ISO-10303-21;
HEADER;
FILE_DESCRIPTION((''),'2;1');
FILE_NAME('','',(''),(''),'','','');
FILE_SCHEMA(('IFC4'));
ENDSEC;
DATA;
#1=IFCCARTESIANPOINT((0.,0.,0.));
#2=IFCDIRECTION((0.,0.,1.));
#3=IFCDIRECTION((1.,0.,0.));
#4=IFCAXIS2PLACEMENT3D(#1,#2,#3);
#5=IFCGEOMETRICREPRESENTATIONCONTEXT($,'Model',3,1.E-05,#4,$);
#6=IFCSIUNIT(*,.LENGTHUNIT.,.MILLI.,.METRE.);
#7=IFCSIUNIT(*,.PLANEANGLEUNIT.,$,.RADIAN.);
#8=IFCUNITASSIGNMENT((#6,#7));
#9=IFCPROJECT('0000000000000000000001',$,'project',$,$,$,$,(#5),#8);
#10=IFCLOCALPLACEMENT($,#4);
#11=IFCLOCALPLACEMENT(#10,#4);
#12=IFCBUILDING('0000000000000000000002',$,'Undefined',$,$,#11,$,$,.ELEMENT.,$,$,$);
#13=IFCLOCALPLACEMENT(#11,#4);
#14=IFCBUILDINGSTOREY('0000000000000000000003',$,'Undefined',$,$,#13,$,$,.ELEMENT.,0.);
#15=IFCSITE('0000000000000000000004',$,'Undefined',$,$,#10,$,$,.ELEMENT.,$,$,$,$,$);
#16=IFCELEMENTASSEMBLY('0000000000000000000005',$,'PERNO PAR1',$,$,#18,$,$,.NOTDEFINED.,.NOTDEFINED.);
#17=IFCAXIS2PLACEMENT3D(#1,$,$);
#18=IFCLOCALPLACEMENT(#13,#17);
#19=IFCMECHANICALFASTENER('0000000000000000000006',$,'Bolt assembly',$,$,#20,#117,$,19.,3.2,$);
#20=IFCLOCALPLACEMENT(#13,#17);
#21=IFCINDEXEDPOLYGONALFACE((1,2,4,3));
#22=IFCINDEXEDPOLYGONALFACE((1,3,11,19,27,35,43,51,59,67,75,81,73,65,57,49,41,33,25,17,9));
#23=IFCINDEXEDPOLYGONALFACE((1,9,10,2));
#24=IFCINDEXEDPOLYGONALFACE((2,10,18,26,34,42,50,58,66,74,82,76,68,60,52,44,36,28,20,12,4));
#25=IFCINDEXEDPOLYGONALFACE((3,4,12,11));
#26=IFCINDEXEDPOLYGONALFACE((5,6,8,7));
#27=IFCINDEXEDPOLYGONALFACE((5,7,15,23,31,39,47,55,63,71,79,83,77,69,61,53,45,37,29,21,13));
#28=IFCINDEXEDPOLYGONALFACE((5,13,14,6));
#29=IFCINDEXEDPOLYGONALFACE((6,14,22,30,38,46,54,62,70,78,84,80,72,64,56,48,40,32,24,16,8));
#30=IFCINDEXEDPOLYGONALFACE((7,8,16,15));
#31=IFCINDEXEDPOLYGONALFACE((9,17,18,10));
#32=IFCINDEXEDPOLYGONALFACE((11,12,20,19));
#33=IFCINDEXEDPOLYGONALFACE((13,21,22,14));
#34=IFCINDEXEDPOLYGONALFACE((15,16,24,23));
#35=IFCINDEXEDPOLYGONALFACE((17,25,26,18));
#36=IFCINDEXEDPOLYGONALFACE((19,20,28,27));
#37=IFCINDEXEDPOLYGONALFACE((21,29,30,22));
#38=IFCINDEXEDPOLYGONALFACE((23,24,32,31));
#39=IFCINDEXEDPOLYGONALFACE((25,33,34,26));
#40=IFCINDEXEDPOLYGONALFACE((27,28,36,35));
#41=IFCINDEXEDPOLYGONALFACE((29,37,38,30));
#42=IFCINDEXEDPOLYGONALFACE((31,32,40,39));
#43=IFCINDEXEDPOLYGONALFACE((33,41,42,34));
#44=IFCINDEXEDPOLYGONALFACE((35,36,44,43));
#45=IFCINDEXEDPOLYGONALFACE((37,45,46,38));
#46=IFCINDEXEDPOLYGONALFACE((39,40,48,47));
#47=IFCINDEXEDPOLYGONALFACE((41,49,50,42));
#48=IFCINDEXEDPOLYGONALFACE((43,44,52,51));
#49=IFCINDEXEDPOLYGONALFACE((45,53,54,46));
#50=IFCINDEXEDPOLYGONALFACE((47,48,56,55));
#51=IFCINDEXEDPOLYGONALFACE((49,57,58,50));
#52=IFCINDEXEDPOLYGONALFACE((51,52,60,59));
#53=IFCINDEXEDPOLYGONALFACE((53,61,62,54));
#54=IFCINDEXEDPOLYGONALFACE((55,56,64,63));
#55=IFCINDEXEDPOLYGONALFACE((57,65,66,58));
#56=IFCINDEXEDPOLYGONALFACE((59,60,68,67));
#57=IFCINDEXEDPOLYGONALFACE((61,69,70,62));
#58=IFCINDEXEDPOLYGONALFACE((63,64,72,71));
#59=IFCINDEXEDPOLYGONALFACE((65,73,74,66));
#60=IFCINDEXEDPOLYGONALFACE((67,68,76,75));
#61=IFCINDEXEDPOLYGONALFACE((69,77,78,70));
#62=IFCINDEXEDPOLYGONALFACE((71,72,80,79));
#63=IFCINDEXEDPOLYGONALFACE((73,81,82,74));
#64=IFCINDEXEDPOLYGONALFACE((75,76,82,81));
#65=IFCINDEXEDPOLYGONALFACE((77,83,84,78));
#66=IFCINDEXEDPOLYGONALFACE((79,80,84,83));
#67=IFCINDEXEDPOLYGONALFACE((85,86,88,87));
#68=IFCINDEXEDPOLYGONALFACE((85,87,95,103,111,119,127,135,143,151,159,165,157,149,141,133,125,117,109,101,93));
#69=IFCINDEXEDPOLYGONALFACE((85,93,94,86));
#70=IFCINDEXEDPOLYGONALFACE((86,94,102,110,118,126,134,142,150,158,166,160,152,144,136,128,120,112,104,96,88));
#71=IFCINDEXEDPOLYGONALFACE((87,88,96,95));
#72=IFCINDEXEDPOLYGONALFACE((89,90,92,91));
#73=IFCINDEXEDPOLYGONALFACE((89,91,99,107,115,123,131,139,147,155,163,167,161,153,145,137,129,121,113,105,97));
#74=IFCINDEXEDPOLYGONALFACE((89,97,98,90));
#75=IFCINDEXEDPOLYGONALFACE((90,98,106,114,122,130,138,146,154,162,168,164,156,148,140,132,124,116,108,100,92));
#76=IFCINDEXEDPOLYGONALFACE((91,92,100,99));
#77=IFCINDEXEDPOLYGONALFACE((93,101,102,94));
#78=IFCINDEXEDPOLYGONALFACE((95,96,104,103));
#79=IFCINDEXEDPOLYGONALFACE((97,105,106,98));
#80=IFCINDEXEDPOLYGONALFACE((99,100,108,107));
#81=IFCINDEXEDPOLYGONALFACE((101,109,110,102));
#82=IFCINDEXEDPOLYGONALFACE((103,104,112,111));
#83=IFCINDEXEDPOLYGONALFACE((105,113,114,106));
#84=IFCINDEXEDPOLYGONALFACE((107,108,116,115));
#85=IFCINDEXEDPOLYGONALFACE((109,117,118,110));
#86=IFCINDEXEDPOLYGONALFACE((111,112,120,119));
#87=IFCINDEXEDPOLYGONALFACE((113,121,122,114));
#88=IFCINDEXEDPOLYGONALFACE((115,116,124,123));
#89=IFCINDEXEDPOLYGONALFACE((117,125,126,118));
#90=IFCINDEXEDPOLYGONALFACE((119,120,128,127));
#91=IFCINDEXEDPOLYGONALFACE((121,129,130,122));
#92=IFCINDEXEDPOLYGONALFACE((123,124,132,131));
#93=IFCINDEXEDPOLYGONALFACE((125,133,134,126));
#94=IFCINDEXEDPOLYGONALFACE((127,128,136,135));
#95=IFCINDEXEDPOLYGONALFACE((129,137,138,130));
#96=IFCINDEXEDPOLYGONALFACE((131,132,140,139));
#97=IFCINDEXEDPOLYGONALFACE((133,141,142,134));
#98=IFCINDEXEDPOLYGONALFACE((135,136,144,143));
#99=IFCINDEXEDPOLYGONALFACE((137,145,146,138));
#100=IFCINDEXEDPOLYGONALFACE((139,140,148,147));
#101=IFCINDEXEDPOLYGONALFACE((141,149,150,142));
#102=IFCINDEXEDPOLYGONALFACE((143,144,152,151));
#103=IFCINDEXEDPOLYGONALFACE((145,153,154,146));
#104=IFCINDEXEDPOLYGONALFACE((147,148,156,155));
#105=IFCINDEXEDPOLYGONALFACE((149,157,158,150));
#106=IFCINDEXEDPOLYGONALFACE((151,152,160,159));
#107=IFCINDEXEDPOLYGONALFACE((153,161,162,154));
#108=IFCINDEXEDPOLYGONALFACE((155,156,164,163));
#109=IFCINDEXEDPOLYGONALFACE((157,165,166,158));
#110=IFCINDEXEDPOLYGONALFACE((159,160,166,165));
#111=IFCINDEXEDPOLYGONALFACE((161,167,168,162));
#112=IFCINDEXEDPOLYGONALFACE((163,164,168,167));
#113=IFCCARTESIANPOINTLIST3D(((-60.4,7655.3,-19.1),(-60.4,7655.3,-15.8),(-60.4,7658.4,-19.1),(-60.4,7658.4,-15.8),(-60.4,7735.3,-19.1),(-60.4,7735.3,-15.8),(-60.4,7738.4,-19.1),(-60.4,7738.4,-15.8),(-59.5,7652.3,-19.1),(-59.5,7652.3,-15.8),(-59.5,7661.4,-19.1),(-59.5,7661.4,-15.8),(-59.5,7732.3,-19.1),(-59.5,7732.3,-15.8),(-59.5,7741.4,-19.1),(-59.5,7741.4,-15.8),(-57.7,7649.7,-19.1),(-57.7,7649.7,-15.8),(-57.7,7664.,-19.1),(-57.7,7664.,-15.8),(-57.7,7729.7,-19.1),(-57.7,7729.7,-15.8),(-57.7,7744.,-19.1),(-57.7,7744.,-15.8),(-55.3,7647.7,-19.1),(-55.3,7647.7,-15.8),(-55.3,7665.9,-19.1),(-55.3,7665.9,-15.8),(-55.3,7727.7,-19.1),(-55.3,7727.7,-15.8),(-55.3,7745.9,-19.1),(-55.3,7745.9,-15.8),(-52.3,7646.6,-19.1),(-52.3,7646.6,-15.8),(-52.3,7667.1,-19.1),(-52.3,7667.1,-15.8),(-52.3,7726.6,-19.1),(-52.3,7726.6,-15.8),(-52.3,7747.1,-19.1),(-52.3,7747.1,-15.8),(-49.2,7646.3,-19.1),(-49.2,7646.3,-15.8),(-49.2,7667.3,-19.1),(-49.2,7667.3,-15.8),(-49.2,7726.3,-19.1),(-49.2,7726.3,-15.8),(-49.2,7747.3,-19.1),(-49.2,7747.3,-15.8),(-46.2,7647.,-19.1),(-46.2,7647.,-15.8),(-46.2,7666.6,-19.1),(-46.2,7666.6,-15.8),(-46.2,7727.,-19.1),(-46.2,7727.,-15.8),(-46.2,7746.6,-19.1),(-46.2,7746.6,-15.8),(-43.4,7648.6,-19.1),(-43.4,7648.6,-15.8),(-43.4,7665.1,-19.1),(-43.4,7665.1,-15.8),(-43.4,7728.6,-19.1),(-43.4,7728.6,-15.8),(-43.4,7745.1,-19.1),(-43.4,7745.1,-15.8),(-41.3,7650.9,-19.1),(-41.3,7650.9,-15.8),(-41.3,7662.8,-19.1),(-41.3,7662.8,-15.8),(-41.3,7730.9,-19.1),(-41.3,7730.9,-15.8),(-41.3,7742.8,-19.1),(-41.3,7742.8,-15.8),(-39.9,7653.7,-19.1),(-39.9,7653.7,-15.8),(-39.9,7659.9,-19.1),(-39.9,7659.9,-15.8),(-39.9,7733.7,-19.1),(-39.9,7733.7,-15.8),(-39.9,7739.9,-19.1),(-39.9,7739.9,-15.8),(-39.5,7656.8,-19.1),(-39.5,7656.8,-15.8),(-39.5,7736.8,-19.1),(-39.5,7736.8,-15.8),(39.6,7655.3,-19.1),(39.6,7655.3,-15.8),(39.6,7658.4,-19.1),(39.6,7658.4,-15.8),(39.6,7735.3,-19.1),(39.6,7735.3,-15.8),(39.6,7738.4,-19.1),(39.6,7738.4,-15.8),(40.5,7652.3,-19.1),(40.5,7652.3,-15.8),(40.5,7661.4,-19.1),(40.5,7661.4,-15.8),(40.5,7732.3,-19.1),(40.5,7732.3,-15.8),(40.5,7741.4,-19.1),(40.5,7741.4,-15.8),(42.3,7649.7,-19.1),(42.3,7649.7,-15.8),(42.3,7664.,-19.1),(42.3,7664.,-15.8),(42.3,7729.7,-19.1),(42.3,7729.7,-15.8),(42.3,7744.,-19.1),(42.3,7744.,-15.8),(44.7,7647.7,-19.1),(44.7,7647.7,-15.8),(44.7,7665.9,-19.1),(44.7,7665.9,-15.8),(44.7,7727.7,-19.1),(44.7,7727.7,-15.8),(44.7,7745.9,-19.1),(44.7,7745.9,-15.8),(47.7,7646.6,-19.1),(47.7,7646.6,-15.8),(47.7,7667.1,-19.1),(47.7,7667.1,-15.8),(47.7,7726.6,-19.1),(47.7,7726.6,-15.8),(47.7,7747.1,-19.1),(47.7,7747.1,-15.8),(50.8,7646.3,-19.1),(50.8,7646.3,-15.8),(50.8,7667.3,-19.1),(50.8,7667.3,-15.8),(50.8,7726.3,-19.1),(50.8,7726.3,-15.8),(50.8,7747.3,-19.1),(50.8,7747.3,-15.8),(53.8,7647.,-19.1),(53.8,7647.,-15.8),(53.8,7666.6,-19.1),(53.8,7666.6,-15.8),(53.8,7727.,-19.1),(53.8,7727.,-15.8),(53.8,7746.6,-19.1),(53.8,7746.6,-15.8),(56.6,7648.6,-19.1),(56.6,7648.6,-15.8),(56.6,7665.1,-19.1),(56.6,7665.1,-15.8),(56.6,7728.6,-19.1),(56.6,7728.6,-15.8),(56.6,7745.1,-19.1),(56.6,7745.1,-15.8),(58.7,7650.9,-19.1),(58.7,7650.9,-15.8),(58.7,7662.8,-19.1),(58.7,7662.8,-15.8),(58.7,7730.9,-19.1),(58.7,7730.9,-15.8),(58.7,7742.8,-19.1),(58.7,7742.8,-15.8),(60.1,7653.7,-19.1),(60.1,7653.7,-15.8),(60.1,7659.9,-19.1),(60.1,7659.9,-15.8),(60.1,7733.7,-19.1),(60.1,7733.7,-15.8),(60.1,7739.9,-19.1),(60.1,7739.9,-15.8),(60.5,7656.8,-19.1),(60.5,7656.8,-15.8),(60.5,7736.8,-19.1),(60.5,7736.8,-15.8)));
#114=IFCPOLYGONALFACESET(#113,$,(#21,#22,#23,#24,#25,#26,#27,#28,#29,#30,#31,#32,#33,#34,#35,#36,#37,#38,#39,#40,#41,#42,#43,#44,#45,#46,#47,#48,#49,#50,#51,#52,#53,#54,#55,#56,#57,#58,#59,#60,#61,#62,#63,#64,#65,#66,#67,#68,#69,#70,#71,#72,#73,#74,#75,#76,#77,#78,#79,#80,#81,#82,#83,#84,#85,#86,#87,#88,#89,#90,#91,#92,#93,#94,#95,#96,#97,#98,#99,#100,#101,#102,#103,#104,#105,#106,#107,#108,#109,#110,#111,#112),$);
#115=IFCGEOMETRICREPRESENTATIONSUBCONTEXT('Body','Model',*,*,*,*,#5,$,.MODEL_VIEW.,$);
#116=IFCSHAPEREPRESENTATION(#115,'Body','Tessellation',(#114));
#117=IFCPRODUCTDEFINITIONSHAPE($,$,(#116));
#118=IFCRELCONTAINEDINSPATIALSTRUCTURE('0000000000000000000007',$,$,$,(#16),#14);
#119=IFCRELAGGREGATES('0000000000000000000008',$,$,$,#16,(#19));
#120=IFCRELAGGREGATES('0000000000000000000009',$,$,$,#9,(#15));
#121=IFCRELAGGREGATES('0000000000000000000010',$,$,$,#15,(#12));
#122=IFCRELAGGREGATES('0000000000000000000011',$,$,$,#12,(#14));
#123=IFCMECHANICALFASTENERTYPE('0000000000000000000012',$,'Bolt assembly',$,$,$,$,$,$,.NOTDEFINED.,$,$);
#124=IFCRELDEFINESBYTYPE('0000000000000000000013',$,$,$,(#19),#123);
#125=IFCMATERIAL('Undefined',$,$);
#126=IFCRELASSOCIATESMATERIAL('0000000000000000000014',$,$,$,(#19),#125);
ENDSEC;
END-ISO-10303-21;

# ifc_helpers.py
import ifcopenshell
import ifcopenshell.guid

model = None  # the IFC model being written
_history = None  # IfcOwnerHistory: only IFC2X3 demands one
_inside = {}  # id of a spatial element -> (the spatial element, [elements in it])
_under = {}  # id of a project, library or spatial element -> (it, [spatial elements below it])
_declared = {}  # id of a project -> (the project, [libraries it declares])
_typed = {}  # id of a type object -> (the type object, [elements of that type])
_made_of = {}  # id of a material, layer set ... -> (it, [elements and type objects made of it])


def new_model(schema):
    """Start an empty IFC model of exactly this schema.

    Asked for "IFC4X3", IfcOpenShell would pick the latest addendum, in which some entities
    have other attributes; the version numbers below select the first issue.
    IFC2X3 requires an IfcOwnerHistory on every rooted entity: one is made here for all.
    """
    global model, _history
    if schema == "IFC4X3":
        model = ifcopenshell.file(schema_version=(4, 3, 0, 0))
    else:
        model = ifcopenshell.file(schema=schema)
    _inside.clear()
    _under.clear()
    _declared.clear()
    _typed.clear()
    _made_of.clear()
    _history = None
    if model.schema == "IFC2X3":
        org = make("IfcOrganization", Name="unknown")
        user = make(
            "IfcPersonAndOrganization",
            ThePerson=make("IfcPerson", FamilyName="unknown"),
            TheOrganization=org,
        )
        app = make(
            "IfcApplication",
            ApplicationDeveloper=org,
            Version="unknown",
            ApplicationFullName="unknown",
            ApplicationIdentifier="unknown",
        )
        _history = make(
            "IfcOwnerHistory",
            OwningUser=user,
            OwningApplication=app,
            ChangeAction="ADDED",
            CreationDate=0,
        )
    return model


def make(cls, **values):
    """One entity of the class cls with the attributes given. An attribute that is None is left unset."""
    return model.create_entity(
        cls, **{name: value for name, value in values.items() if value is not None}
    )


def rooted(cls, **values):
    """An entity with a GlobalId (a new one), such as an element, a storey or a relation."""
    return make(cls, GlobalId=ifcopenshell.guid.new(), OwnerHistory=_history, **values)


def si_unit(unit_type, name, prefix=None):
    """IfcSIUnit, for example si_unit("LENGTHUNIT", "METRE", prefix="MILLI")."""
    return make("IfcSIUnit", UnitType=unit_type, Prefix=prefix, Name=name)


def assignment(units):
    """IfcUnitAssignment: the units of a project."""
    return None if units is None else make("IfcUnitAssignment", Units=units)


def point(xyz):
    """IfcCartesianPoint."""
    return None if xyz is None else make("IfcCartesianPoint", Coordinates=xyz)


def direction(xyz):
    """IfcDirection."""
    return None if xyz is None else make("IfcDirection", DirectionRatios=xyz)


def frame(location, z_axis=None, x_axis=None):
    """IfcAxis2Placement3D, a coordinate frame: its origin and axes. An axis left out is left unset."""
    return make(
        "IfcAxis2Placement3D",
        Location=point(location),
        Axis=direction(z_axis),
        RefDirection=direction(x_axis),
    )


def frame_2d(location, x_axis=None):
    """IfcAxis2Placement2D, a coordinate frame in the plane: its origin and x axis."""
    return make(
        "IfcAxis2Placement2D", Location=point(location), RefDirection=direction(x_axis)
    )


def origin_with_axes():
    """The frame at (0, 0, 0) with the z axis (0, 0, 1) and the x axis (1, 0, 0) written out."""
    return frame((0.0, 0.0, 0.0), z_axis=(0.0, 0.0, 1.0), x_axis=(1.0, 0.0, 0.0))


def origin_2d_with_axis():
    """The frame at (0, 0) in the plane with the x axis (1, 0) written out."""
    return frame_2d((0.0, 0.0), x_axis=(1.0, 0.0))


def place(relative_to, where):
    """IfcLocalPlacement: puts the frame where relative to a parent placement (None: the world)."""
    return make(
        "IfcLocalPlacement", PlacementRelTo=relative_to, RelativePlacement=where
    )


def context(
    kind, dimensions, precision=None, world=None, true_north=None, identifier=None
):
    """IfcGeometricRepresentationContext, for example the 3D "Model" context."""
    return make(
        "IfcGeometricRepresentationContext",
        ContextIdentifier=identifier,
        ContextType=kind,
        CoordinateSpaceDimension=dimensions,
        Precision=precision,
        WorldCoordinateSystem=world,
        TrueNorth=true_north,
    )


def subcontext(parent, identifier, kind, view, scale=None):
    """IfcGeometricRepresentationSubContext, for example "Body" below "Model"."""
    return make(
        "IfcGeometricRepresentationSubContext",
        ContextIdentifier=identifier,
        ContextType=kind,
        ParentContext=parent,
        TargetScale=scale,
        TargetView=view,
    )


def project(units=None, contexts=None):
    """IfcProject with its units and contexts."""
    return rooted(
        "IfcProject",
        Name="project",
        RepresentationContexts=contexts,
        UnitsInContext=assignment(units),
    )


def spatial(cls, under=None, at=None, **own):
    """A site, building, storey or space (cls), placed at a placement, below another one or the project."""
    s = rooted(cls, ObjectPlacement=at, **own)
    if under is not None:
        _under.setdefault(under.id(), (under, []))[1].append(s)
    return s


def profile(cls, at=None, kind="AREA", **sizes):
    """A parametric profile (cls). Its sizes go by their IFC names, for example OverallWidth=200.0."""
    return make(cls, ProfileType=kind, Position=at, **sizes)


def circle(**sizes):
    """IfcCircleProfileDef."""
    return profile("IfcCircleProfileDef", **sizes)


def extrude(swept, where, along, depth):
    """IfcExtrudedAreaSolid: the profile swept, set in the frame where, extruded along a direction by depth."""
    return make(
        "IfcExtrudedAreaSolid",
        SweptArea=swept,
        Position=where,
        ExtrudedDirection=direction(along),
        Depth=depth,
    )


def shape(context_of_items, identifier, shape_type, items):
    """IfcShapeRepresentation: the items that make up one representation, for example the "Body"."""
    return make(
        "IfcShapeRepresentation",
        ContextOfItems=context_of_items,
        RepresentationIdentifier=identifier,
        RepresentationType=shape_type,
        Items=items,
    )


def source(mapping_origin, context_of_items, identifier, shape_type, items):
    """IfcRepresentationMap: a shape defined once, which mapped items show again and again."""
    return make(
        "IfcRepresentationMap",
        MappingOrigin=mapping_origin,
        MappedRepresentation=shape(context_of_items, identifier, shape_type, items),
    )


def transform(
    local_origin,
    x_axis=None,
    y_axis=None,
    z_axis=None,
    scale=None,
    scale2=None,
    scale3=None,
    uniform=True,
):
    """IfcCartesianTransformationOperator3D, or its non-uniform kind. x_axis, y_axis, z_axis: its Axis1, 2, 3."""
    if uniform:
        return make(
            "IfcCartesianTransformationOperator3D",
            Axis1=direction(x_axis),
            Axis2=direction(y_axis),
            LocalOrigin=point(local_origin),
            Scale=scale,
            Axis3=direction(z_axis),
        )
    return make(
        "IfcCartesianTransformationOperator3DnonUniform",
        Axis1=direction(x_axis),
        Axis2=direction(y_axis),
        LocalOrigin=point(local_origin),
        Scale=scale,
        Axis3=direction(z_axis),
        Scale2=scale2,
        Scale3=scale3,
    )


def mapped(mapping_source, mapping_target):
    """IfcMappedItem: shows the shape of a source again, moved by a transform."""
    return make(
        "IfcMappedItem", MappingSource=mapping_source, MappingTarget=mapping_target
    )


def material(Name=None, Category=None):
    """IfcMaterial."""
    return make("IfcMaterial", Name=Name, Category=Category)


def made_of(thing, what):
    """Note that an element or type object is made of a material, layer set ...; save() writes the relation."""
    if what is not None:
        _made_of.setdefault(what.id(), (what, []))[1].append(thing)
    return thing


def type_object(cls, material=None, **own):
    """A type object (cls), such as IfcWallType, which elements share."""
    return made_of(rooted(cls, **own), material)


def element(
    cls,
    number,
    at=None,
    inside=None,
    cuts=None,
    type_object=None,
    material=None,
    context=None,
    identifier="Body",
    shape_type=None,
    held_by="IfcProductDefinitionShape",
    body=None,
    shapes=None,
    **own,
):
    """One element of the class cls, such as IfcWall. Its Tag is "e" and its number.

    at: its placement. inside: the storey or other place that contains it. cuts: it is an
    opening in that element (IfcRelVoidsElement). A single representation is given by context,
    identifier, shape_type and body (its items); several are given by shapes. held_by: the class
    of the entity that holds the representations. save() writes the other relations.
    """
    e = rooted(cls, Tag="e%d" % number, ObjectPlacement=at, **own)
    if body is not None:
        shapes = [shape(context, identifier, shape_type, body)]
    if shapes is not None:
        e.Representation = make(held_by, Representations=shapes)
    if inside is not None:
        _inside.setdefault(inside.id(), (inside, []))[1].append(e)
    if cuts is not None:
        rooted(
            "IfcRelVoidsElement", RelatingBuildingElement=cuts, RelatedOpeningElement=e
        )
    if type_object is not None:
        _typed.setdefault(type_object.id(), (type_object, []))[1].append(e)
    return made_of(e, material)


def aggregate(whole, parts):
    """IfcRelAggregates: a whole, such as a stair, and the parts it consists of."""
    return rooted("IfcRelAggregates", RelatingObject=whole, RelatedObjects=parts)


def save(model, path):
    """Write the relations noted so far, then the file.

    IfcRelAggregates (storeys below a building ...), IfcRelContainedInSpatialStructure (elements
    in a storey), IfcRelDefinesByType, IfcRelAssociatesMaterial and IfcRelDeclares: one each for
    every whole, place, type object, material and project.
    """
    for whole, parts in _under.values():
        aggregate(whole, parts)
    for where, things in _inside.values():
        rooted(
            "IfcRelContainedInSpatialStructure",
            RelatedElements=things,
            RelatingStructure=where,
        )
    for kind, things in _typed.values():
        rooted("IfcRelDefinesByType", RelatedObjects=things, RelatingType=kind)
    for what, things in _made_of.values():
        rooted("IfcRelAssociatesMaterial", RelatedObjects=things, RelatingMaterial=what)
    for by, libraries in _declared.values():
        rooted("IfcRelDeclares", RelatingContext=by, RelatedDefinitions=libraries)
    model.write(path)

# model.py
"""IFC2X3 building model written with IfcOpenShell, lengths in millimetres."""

from ifc_helpers import new_model, si_unit, frame, origin_with_axes, origin_2d_with_axis, place, context, subcontext, project, spatial, circle, extrude, source, transform, mapped, material, type_object, element, aggregate, save


model = new_model("IFC2X3")

# Units and contexts
model_context = context("Model", 3, precision=1e-05, world=origin_with_axes())
body_context = subcontext(model_context, "Body", "Model", "MODEL_VIEW")
ifc_project = project(units=[si_unit("LENGTHUNIT", "METRE", prefix="MILLI"), si_unit("PLANEANGLEUNIT", "RADIAN")], contexts=[model_context])

# Site, building, storey
site_placement = place(None, origin_with_axes())
site = spatial("IfcSite", under=ifc_project, at=site_placement, Name="Undefined", CompositionType="ELEMENT")
building_placement = place(site_placement, origin_with_axes())
building = spatial("IfcBuilding", under=site, at=building_placement, Name="Undefined", CompositionType="ELEMENT")
storey_placement = place(building_placement, origin_with_axes())
storey = spatial("IfcBuildingStorey", under=building, at=storey_placement, Name="Undefined", CompositionType="ELEMENT", Elevation=0.0)

# Element assembly
assembly_1_placement = place(storey_placement, origin_with_axes())
assembly_1 = element("IfcElementAssembly", 1, at=assembly_1_placement, inside=storey, Name="PERNO PAR1", AssemblyPlace="NOTDEFINED", PredefinedType="NOTDEFINED")

# Shared definitions
ifc_material_1 = material(Name="Undefined")
mechanical_fastener_type = type_object("IfcMechanicalFastenerType", Name="Bolt assembly")

# Mechanical fastener
shared_shape_1 = source(origin_with_axes(), body_context, "Body", "SweptSolid", [
    extrude(circle(Radius=10.5, at=origin_2d_with_axis()), frame((0.0, 0.0, 0.0), z_axis=(0.0, 1.0, 0.0), x_axis=(1.0, 0.0, 0.0)), (0.0, 0.0, 1.0), 3.3),
])
mechanical_fastener_1_placement = place(assembly_1_placement, frame((-50.0, 7696.8, -15.8), z_axis=(0.0, 1.0, 0.0), x_axis=(1.0, 0.0, 0.0)))
mechanical_fastener_1 = element("IfcMechanicalFastener", 2, at=mechanical_fastener_1_placement, type_object=mechanical_fastener_type, material=ifc_material_1, Name="Bolt assembly", NominalDiameter=19.0, NominalLength=3.2, context=body_context, shape_type="MappedRepresentation", body=[
    mapped(shared_shape_1, transform((0.0, 0.0, -40.0))),
    mapped(shared_shape_1, transform((100.0, 0.0, -40.0))),
    mapped(shared_shape_1, transform((0.0, 0.0, 40.0))),
    mapped(shared_shape_1, transform((100.0, 0.0, 40.0))),
])
aggregate(assembly_1, [mechanical_fastener_1])

save(model, "model.ifc")
